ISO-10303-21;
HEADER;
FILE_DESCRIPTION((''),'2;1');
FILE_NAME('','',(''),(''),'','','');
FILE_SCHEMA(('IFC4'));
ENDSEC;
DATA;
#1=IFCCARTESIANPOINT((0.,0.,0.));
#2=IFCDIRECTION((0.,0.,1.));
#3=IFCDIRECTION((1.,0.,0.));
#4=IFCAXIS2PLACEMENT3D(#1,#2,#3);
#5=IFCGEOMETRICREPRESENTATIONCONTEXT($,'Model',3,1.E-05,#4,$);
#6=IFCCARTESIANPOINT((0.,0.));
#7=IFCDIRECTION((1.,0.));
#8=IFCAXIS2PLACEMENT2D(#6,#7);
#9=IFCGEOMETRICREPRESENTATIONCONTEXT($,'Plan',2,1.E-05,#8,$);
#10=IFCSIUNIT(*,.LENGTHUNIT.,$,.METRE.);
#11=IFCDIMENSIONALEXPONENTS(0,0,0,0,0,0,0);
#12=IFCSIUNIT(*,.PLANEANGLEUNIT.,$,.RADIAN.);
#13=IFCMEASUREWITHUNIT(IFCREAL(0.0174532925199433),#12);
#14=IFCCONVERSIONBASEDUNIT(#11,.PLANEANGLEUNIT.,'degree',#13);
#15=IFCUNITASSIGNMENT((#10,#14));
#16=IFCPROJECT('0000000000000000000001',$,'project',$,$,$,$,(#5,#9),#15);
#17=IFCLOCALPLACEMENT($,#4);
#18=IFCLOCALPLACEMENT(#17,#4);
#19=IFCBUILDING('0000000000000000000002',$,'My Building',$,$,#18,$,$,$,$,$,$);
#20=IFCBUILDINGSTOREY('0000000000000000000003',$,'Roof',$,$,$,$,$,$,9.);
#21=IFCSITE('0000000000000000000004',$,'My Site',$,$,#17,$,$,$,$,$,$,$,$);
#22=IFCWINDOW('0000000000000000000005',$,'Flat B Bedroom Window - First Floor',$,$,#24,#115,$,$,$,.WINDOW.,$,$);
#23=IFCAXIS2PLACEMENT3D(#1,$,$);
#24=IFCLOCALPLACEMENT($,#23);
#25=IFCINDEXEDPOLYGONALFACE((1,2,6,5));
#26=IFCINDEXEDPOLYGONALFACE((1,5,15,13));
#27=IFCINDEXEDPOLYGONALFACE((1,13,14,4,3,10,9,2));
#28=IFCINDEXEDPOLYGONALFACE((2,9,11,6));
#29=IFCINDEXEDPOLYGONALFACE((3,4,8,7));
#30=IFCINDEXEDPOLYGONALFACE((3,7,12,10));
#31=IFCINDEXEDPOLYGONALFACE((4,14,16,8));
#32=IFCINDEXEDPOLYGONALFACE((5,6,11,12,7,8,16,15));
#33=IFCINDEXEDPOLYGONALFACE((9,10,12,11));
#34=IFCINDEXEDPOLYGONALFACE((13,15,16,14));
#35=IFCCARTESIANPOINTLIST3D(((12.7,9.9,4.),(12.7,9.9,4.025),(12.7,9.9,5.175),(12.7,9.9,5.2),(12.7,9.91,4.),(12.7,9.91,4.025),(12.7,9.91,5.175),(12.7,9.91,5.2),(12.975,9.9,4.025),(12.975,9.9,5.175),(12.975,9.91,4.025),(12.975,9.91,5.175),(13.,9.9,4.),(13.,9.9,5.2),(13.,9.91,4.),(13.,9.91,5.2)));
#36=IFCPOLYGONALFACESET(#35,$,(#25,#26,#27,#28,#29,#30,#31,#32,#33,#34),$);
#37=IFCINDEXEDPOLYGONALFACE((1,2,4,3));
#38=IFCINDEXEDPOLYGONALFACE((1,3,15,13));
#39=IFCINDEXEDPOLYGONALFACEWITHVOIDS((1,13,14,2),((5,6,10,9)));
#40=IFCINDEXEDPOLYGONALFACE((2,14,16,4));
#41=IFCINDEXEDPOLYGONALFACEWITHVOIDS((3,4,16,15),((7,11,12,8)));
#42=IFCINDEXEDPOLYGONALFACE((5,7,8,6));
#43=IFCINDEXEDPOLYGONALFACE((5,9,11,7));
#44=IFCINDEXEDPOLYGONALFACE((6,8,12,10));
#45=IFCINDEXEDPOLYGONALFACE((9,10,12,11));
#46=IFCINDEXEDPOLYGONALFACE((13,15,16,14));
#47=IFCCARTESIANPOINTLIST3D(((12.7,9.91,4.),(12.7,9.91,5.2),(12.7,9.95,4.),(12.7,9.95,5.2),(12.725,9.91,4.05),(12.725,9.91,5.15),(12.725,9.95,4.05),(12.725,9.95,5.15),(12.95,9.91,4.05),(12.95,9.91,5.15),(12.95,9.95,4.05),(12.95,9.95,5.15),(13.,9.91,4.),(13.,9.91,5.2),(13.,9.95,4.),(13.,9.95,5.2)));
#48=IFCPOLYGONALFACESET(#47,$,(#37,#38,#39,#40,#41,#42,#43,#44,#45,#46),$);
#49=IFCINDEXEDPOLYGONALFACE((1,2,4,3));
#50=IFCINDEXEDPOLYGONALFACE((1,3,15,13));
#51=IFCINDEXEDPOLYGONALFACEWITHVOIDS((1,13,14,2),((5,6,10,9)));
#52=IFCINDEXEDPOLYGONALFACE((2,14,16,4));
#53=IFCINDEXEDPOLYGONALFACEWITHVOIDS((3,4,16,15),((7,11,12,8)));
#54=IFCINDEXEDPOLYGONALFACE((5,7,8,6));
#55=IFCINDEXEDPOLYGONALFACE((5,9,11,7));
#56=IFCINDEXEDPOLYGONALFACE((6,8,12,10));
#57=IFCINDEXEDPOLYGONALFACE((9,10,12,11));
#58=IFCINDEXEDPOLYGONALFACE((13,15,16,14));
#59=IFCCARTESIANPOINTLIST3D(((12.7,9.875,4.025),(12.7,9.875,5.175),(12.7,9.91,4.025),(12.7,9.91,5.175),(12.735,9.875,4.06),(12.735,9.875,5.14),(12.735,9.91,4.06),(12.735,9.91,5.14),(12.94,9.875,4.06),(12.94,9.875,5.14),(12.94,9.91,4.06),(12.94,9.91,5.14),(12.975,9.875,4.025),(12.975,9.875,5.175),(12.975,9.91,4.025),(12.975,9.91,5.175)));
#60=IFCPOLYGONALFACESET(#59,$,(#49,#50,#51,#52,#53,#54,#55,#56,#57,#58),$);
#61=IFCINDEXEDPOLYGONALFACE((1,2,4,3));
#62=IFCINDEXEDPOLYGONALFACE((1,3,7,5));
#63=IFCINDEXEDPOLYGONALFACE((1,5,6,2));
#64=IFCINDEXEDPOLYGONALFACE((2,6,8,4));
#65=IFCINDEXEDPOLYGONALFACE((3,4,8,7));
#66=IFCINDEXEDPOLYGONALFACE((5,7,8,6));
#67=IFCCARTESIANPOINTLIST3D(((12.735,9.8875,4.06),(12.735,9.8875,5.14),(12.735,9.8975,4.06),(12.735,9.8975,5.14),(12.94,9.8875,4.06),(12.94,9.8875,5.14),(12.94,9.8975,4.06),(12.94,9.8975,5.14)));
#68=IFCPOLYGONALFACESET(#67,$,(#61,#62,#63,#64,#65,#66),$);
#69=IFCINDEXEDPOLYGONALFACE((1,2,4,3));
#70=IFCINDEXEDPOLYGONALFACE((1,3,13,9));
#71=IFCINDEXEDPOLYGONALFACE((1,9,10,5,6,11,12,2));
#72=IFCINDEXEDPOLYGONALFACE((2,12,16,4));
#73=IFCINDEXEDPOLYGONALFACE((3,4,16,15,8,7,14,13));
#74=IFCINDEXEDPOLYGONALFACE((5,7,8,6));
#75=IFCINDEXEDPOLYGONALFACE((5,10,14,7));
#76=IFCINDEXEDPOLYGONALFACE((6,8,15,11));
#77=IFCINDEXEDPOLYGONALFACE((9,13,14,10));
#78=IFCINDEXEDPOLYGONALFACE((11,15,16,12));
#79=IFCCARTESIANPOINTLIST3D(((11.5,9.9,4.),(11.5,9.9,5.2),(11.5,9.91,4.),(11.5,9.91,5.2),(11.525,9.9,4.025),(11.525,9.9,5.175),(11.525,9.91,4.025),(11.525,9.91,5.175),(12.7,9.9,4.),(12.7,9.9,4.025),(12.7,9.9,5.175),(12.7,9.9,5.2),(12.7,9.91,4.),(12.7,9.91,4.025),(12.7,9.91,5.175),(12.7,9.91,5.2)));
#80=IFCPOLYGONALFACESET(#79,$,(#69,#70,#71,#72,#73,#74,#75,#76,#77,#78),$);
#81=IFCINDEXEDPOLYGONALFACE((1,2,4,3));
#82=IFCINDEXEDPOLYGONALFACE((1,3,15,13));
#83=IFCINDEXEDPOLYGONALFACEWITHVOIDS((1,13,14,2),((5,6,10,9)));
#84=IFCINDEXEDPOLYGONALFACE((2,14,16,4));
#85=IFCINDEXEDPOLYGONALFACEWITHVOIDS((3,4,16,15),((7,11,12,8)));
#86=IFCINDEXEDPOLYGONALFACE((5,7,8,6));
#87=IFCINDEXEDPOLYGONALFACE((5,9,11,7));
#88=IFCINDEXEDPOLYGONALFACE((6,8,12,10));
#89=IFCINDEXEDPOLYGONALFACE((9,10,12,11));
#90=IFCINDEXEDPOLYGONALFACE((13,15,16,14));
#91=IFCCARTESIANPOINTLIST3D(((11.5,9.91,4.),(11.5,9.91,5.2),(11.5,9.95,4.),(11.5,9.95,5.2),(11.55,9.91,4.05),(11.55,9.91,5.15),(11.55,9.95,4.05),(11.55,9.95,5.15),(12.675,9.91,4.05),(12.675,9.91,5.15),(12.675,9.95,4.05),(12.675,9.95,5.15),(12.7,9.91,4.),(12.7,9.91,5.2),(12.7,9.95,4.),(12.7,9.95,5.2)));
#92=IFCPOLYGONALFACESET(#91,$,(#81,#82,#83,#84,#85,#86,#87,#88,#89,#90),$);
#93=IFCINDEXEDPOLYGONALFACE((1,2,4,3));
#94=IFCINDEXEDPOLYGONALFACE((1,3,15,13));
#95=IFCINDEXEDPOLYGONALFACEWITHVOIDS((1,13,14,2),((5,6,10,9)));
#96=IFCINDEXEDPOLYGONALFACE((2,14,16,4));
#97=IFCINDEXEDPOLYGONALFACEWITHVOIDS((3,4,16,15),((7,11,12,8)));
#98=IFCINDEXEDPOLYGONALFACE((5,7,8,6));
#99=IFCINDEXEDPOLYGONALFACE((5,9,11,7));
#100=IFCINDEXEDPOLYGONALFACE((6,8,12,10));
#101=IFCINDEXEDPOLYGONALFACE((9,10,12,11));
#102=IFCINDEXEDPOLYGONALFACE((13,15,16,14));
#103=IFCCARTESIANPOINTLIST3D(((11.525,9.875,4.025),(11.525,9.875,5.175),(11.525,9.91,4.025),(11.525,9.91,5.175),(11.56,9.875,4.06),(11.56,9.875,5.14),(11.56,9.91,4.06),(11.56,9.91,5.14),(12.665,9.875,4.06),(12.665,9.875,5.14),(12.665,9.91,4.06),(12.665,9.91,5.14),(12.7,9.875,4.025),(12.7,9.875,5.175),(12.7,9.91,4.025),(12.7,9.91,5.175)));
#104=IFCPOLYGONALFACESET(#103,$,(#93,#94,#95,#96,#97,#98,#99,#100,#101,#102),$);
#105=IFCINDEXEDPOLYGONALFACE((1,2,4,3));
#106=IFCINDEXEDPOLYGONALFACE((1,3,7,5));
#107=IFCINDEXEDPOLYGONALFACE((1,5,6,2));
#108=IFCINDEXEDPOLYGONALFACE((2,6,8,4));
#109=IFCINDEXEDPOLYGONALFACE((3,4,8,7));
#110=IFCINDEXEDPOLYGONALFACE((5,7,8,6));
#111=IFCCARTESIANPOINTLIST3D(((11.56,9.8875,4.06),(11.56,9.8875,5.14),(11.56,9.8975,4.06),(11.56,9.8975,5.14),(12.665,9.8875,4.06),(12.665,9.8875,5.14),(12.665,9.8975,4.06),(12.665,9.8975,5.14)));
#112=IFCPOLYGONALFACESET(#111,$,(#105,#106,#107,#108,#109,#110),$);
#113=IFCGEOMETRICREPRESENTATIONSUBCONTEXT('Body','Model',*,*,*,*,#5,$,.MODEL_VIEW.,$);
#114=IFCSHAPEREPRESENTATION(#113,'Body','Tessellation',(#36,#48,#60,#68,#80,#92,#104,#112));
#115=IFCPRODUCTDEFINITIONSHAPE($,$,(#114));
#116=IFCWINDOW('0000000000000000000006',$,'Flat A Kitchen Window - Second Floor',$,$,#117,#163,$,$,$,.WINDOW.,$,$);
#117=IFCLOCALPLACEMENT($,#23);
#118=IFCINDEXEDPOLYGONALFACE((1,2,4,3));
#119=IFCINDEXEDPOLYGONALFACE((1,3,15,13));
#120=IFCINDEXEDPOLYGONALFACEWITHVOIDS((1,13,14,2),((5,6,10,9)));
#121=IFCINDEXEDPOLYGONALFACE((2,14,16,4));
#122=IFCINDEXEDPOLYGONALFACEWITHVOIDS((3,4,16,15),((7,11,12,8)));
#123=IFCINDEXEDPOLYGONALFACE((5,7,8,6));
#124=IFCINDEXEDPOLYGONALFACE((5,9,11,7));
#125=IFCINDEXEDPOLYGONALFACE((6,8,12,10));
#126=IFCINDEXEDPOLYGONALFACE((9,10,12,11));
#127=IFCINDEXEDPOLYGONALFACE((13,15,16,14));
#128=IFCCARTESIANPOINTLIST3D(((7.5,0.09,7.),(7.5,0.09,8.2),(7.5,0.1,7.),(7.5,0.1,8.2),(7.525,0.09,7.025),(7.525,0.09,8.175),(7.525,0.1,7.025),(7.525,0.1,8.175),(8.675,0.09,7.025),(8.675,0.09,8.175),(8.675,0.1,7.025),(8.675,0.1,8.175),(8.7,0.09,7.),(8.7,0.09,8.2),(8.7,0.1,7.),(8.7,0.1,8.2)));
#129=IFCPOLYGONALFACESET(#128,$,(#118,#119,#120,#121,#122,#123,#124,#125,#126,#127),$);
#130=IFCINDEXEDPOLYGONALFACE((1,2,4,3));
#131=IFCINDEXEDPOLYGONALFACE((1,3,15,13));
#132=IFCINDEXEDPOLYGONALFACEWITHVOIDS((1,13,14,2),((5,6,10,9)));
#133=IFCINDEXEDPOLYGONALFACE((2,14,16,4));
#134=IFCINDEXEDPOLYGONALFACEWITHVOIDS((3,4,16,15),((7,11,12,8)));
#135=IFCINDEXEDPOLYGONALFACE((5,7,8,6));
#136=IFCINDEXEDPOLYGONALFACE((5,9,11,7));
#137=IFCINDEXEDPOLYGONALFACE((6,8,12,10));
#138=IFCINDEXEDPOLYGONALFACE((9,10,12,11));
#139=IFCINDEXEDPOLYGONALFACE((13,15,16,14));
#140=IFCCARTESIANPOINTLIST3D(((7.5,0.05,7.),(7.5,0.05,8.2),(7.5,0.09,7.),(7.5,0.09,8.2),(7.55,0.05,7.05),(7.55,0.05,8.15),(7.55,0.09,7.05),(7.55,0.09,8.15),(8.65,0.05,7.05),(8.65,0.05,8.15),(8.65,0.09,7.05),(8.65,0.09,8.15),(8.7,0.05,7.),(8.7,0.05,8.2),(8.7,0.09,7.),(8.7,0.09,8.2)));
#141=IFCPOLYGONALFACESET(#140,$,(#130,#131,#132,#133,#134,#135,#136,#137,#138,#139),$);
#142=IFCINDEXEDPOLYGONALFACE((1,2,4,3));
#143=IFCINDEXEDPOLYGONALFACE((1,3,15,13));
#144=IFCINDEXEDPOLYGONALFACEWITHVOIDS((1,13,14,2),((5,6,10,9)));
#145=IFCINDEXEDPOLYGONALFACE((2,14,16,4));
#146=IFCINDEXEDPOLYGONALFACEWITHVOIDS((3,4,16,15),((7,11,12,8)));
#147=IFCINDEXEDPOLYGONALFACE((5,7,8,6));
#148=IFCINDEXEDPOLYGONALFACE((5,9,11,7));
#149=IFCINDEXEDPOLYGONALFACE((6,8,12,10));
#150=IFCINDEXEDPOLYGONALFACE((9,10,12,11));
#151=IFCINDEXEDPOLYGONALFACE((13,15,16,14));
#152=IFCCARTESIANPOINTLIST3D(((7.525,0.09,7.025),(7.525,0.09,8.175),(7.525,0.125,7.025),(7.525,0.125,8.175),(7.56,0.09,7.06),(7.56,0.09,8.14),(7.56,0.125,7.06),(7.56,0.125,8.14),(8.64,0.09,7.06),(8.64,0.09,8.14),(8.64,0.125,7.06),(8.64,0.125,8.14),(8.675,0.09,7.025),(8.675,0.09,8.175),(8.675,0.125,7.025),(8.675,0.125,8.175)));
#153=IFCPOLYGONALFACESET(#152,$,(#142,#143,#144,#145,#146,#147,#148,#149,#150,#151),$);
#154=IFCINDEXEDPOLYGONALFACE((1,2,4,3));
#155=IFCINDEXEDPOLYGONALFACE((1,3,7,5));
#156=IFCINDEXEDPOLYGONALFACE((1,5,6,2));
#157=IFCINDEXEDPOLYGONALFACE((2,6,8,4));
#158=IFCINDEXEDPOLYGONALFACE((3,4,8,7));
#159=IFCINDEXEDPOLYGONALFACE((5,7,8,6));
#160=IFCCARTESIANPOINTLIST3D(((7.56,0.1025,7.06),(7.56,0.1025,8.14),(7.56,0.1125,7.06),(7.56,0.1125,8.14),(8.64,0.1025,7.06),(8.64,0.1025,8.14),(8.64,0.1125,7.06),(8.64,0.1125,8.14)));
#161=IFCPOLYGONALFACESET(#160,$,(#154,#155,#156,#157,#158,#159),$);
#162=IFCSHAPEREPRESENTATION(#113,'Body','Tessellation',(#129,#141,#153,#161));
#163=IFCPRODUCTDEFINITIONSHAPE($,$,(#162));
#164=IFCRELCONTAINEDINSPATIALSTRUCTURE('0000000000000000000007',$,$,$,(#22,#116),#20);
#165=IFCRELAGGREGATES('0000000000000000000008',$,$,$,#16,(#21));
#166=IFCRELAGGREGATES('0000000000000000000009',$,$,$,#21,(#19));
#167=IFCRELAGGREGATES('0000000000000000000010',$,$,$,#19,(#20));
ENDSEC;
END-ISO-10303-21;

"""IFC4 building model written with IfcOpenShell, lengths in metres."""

from ifc_helpers import new_model, entity, si_unit, converted_unit, frame, origin_with_axes, origin_2d_with_axis, place, context, subcontext, project, spatial, line, indexed_curve, outline, extrude, element, save


model = new_model("IFC4")

# Units and contexts
model_context = context("Model", 3, precision=1e-05, world=origin_with_axes())
plan_context = context("Plan", 2, precision=1e-05, world=origin_2d_with_axis())
body_context = subcontext(model_context, "Body", "Model", "MODEL_VIEW")
ifc_project = project(units=[si_unit("LENGTHUNIT", "METRE"), converted_unit("PLANEANGLEUNIT", "degree", entity("IfcReal", 0.0174532925199433), si_unit("PLANEANGLEUNIT", "RADIAN"), dimensions=[0, 0, 0, 0, 0, 0, 0])], contexts=[model_context, plan_context])

# Site, building, storey
site_placement = place(None, origin_with_axes())
site = spatial("IfcSite", under=ifc_project, at=site_placement, Name="My Site")
building_placement = place(site_placement, origin_with_axes())
building = spatial("IfcBuilding", under=site, at=building_placement, Name="My Building")
storey = spatial("IfcBuildingStorey", under=building, Name="Roof", Elevation=9.0)

# Windows
window_1_placement = place(None, frame((13.0, 10.0, 4.0), z_axis=(0.0, 0.0, 1.0), x_axis=(-1.0, 0.0, 0.0)))
element("IfcWindow", 1, at=window_1_placement, inside=storey, Name="Flat B Bedroom Window - First Floor", PredefinedType="WINDOW", context=body_context, shape_type="SweptSolid", body=[
    extrude(outline(indexed_curve([(0.3, 0.0), (0.0, 0.0), (0.0, 1.2), (0.3, 1.2), (0.3, 1.175), (0.025, 1.175), (0.025, 0.025), (0.3, 0.025)], segments=[line(1, 2, 3, 4, 5, 6, 7, 8, 1)])), frame((0.0, 0.09, 0.0), z_axis=(0.0, -1.0, 0.0), x_axis=(1.0, 0.0, 0.0)), (0.0, 0.0, -1.0), 0.01),
    extrude(outline(indexed_curve([(0.0, 0.0), (0.3, 0.0), (0.3, 1.2), (0.0, 1.2)], segments=[line(1, 2, 3, 4, 1)]), holes=[indexed_curve([(0.05, 0.05), (0.275, 0.05), (0.275, 1.15), (0.05, 1.15)], segments=[line(1, 2, 3, 4, 1)])]), frame((0.0, 0.05, 0.0), z_axis=(0.0, -1.0, 0.0), x_axis=(1.0, 0.0, 0.0)), (0.0, 0.0, -1.0), 0.04),
    extrude(outline(indexed_curve([(0.0, 0.0), (0.275, 0.0), (0.275, 1.15), (0.0, 1.15)], segments=[line(1, 2, 3, 4, 1)]), holes=[indexed_curve([(0.035, 0.035), (0.24, 0.035), (0.24, 1.115), (0.035, 1.115)], segments=[line(1, 2, 3, 4, 1)])]), frame((0.025, 0.09, 0.025), z_axis=(0.0, -1.0, 0.0), x_axis=(1.0, 0.0, 0.0)), (0.0, 0.0, -1.0), 0.035),
    extrude(outline(indexed_curve([(0.035, 0.035), (0.24, 0.035), (0.24, 1.115), (0.035, 1.115)], segments=[line(1, 2, 3, 4, 1)])), frame((0.025, 0.1025, 0.025), z_axis=(0.0, -1.0, 0.0), x_axis=(1.0, 0.0, 0.0)), (0.0, 0.0, -1.0), 0.01),
    extrude(outline(indexed_curve([(0.0, 1.2), (1.2, 1.2), (1.2, 0.0), (0.0, 0.0), (0.0, 0.025), (1.175, 0.025), (1.175, 1.175), (0.0, 1.175)], segments=[line(1, 2, 3, 4, 5, 6, 7, 8, 1)])), frame((0.3, 0.09, 0.0), z_axis=(0.0, -1.0, 0.0), x_axis=(1.0, 0.0, 0.0)), (0.0, 0.0, -1.0), 0.01),
    extrude(outline(indexed_curve([(0.0, 0.0), (1.2, 0.0), (1.2, 1.2), (0.0, 1.2)], segments=[line(1, 2, 3, 4, 1)]), holes=[indexed_curve([(0.025, 0.05), (1.15, 0.05), (1.15, 1.15), (0.025, 1.15)], segments=[line(1, 2, 3, 4, 1)])]), frame((0.3, 0.05, 0.0), z_axis=(0.0, -1.0, 0.0), x_axis=(1.0, 0.0, 0.0)), (0.0, 0.0, -1.0), 0.04),
    extrude(outline(indexed_curve([(0.0, 0.0), (1.175, 0.0), (1.175, 1.15), (0.0, 1.15)], segments=[line(1, 2, 3, 4, 1)]), holes=[indexed_curve([(0.035, 0.035), (1.14, 0.035), (1.14, 1.115), (0.035, 1.115)], segments=[line(1, 2, 3, 4, 1)])]), frame((0.3, 0.09, 0.025), z_axis=(0.0, -1.0, 0.0), x_axis=(1.0, 0.0, 0.0)), (0.0, 0.0, -1.0), 0.035),
    extrude(outline(indexed_curve([(0.035, 0.035), (1.14, 0.035), (1.14, 1.115), (0.035, 1.115)], segments=[line(1, 2, 3, 4, 1)])), frame((0.3, 0.1025, 0.025), z_axis=(0.0, -1.0, 0.0), x_axis=(1.0, 0.0, 0.0)), (0.0, 0.0, -1.0), 0.01),
])
window_2_placement = place(None, frame((7.5, 0.0, 7.0), z_axis=(0.0, 0.0, 1.0), x_axis=(1.0, 0.0, 0.0)))
element("IfcWindow", 2, at=window_2_placement, inside=storey, Name="Flat A Kitchen Window - Second Floor", PredefinedType="WINDOW", context=body_context, shape_type="SweptSolid", body=[
    extrude(outline(indexed_curve([(0.0, 0.0), (1.2, 0.0), (1.2, 1.2), (0.0, 1.2)], segments=[line(1, 2, 3, 4, 1)]), holes=[indexed_curve([(0.025, 0.025), (1.175, 0.025), (1.175, 1.175), (0.025, 1.175)], segments=[line(1, 2, 3, 4, 1)])]), frame((0.0, 0.09, 0.0), z_axis=(0.0, -1.0, 0.0), x_axis=(1.0, 0.0, 0.0)), (0.0, 0.0, -1.0), 0.01),
    extrude(outline(indexed_curve([(0.0, 0.0), (1.2, 0.0), (1.2, 1.2), (0.0, 1.2)], segments=[line(1, 2, 3, 4, 1)]), holes=[indexed_curve([(0.05, 0.05), (1.15, 0.05), (1.15, 1.15), (0.05, 1.15)], segments=[line(1, 2, 3, 4, 1)])]), frame((0.0, 0.05, 0.0), z_axis=(0.0, -1.0, 0.0), x_axis=(1.0, 0.0, 0.0)), (0.0, 0.0, -1.0), 0.04),
    extrude(outline(indexed_curve([(0.0, 0.0), (1.15, 0.0), (1.15, 1.15), (0.0, 1.15)], segments=[line(1, 2, 3, 4, 1)]), holes=[indexed_curve([(0.035, 0.035), (1.115, 0.035), (1.115, 1.115), (0.035, 1.115)], segments=[line(1, 2, 3, 4, 1)])]), frame((0.025, 0.09, 0.025), z_axis=(0.0, -1.0, 0.0), x_axis=(1.0, 0.0, 0.0)), (0.0, 0.0, -1.0), 0.035),
    extrude(outline(indexed_curve([(0.035, 0.035), (1.115, 0.035), (1.115, 1.115), (0.035, 1.115)], segments=[line(1, 2, 3, 4, 1)])), frame((0.025, 0.1025, 0.025), z_axis=(0.0, -1.0, 0.0), x_axis=(1.0, 0.0, 0.0)), (0.0, 0.0, -1.0), 0.01),
])

save(model, "model.ifc")
